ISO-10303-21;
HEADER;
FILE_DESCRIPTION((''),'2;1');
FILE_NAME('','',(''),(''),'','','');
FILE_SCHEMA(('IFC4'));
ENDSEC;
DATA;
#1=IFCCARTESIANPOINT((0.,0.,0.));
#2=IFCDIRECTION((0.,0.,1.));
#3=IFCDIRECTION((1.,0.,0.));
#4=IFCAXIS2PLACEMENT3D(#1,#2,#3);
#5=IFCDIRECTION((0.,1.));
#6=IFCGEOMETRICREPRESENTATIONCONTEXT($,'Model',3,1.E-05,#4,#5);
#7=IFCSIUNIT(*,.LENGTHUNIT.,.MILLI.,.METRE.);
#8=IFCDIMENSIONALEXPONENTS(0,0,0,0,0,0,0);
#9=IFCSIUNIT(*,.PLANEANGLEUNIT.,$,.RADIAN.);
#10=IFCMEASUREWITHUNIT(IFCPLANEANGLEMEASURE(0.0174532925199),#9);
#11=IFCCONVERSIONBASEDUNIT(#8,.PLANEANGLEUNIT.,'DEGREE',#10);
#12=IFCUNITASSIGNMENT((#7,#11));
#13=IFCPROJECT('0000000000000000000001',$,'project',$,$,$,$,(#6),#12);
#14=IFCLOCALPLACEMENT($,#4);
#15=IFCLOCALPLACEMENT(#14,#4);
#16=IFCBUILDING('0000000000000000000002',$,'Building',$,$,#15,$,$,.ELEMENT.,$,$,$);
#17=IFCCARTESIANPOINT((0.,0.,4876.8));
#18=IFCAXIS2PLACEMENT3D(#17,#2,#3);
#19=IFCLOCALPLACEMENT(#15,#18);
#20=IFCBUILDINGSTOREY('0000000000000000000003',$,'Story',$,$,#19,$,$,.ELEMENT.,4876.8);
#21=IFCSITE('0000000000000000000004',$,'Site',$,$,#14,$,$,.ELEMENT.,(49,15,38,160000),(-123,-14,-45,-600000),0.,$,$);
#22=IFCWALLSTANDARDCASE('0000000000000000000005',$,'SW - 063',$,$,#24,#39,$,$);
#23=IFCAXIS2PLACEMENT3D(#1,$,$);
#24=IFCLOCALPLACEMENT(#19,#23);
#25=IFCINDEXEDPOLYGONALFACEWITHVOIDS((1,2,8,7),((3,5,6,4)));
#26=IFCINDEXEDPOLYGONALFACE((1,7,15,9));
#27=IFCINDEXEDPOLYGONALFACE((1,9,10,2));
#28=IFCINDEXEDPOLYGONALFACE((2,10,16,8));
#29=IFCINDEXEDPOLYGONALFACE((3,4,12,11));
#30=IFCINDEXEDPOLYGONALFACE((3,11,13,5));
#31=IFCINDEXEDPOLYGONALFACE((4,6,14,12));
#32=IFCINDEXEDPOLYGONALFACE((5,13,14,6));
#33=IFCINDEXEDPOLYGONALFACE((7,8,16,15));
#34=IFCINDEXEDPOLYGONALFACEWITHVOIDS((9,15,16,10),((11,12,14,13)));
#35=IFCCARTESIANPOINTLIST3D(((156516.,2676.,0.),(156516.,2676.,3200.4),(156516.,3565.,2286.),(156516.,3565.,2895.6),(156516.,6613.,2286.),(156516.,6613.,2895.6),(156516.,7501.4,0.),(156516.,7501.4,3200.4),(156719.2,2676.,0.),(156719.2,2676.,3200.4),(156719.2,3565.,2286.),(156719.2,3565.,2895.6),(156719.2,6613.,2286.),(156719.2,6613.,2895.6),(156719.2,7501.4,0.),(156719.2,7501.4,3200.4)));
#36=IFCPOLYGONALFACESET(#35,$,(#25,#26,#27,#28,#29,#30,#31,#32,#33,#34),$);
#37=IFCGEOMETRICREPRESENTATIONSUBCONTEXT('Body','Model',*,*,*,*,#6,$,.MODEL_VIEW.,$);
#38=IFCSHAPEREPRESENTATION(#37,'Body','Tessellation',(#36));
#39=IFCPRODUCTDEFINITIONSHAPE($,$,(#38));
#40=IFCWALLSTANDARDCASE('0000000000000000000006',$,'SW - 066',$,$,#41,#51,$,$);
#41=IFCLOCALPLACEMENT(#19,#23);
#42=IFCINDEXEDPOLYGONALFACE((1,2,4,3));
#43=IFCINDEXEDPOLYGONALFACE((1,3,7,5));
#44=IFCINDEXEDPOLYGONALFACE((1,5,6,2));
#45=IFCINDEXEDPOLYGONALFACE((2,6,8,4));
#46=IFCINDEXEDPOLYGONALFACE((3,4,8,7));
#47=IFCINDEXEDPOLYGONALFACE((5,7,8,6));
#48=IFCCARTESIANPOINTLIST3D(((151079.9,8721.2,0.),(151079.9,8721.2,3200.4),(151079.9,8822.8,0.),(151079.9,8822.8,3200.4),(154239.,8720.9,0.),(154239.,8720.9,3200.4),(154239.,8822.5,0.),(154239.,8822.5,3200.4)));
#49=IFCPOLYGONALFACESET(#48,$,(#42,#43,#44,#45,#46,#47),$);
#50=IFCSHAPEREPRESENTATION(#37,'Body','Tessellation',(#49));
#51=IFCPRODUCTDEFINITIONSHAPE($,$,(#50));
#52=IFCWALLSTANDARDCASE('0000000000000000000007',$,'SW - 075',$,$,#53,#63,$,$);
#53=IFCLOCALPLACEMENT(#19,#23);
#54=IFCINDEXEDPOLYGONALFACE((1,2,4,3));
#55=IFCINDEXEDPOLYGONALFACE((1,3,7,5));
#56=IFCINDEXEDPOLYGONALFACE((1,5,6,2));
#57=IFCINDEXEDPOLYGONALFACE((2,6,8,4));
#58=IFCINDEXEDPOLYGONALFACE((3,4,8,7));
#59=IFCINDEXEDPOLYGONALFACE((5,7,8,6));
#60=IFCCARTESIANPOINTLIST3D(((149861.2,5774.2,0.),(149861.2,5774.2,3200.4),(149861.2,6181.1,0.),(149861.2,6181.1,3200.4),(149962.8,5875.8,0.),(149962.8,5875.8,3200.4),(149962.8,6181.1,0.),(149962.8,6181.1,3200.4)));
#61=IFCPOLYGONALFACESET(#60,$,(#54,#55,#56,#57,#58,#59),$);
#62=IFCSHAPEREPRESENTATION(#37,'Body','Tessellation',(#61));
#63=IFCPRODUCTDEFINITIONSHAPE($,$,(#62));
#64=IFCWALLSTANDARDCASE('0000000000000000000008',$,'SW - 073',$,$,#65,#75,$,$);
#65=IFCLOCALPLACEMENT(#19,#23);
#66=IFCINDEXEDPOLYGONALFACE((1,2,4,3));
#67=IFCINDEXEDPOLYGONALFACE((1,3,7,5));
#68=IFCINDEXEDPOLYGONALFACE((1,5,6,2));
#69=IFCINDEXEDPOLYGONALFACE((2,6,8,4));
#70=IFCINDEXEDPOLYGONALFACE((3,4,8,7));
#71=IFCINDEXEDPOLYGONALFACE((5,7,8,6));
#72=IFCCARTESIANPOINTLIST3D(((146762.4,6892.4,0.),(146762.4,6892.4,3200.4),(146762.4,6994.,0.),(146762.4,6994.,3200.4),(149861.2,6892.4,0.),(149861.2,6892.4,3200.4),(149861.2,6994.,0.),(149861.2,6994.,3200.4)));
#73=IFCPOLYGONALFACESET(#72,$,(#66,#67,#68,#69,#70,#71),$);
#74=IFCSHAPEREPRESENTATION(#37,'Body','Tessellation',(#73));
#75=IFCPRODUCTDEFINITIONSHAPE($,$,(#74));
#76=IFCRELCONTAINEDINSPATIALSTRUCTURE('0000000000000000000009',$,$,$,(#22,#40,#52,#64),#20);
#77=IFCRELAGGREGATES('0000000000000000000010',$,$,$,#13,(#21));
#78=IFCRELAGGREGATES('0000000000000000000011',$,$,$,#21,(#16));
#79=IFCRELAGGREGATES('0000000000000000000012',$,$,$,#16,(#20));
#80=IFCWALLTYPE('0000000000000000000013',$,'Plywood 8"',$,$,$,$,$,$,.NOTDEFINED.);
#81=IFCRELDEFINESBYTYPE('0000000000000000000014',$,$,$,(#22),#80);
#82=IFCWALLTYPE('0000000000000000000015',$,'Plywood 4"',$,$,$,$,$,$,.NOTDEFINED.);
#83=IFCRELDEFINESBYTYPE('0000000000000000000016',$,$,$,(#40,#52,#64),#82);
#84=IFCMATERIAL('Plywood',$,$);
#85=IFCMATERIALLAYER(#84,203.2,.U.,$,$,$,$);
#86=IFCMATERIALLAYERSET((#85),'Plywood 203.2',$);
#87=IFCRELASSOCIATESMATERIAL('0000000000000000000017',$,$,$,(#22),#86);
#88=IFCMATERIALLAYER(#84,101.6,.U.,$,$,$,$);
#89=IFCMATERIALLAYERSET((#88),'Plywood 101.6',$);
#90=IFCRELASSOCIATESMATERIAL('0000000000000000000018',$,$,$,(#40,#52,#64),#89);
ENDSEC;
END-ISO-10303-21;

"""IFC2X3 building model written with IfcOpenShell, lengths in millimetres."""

from ifc_helpers import new_model, entity, si_unit, converted_unit, direction, frame, origin_with_axes, origin_2d_with_axis, place, context, subcontext, project, spatial, polyline, rectangle, outline, extrude, material, layer, layer_set, layer_usage, type_object, element, save


model = new_model("IFC2X3")

# Units and contexts
model_context = context("Model", 3, precision=1e-05, world=origin_with_axes(), true_north=direction((0.0, 1.0)))
body_context = subcontext(model_context, "Body", "Model", "MODEL_VIEW")
ifc_project = project(units=[si_unit("LENGTHUNIT", "METRE", prefix="MILLI"), converted_unit("PLANEANGLEUNIT", "DEGREE", entity("IfcPlaneAngleMeasure", 0.0174532925199), si_unit("PLANEANGLEUNIT", "RADIAN"), dimensions=[0, 0, 0, 0, 0, 0, 0])], contexts=[model_context])

# Site, building, storey
site_placement = place(None, origin_with_axes())
site = spatial("IfcSite", under=ifc_project, at=site_placement, Name="Site", CompositionType="ELEMENT", RefLatitude=(49, 15, 38, 160000), RefLongitude=(-123, -14, -45, -600000), RefElevation=0.0)
building_placement = place(site_placement, origin_with_axes())
building = spatial("IfcBuilding", under=site, at=building_placement, Name="Building", CompositionType="ELEMENT")
storey_placement = place(building_placement, frame((0.0, 0.0, 4876.8), z_axis=(0.0, 0.0, 1.0), x_axis=(1.0, 0.0, 0.0)))
storey = spatial("IfcBuildingStorey", under=building, at=storey_placement, Name="Story", CompositionType="ELEMENT", Elevation=4876.8)

# Shared definitions
ifc_material_1 = material(Name="Plywood")
ifc_layer_1 = layer(ifc_material_1, 203.2, ventilated="UNKNOWN")
ifc_layer_set_1 = layer_set([ifc_layer_1], Name="Plywood 203.2")
wall_type_1 = type_object("IfcWallType", Name="Plywood 8\"", PredefinedType="NOTDEFINED")

# Wall, opening
ifc_layer_usage_1 = layer_usage(ifc_layer_set_1, "AXIS2", "POSITIVE", 0.0)
wall_1_placement = place(storey_placement, frame((156516.0, 7501.4, 0.0), z_axis=(0.0, 0.0, 1.0), x_axis=(0.0, -1.0, 0.0)))
wall_1 = element("IfcWallStandardCase", 1, at=wall_1_placement, inside=storey, type_object=wall_type_1, material=ifc_layer_usage_1, Name="SW - 063", context=body_context, shape_type="SweptSolid", body=[
    extrude(outline(polyline([(0.0, 0.0), (4825.5, 0.0), (4825.5, 203.2), (0.0, 203.2), (0.0, 0.0)])), origin_with_axes(), (0.0, 0.0, 1.0), 3200.4),
])
opening_1_placement = place(wall_1_placement, frame((2412.5, 0.0, 2286.0), z_axis=(0.0, 0.0, 1.0), x_axis=(1.0, 0.0, 0.0)))
element("IfcOpeningElement", 2, at=opening_1_placement, cuts=wall_1, context=body_context, shape_type="SweptSolid", body=[
    extrude(rectangle(XDim=3048.0, YDim=609.6, at=origin_2d_with_axis()), frame((0.0, -203.2, 304.8), z_axis=(0.0, -1.0, 0.0), x_axis=(-1.0, 0.0, 0.0)), (0.0, 0.0, -1.0), 609.6),
])

# Shared definitions
ifc_layer_2 = layer(ifc_material_1, 101.6, ventilated="UNKNOWN")
ifc_layer_set_2 = layer_set([ifc_layer_2], Name="Plywood 101.6")
wall_type_2 = type_object("IfcWallType", Name="Plywood 4\"", PredefinedType="NOTDEFINED")

# Walls
ifc_layer_usage_2 = layer_usage(ifc_layer_set_2, "AXIS2", "POSITIVE", 0.0)
wall_2_placement = place(storey_placement, frame((151079.9, 8721.2, 0.0), z_axis=(0.0, 0.0, 1.0), x_axis=(1.0, -0.000087, 0.0)))
element("IfcWallStandardCase", 3, at=wall_2_placement, inside=storey, type_object=wall_type_2, material=ifc_layer_usage_2, Name="SW - 066", context=body_context, shape_type="SweptSolid", body=[
    extrude(outline(polyline([(0.0, 0.0), (3159.2, 0.0), (3159.2, 101.6), (0.0, 101.6), (0.0, 0.0)])), origin_with_axes(), (0.0, 0.0, 1.0), 3200.4),
])
ifc_layer_usage_3 = layer_usage(ifc_layer_set_2, "AXIS2", "POSITIVE", 0.0)
wall_3_placement = place(storey_placement, frame((149861.2, 6181.1, 0.0), z_axis=(0.0, 0.0, 1.0), x_axis=(0.0, -1.0, 0.0)))
element("IfcWallStandardCase", 4, at=wall_3_placement, inside=storey, type_object=wall_type_2, material=ifc_layer_usage_3, Name="SW - 075", context=body_context, shape_type="SweptSolid", body=[
    extrude(outline(polyline([(0.0, 0.0), (406.9, 0.0), (305.3, 101.6), (0.0, 101.6), (0.0, 0.0)])), origin_with_axes(), (0.0, 0.0, 1.0), 3200.4),
])

# Wall
ifc_layer_usage_4 = layer_usage(ifc_layer_set_2, "AXIS2", "POSITIVE", 0.0)
wall_4_placement = place(storey_placement, frame((149861.2, 6994.0, 0.0), z_axis=(0.0, 0.0, 1.0), x_axis=(-1.0, 0.0, 0.0)))
element("IfcWallStandardCase", 5, at=wall_4_placement, inside=storey, type_object=wall_type_2, material=ifc_layer_usage_4, Name="SW - 073", context=body_context, shape_type="SweptSolid", body=[
    extrude(outline(polyline([(0.0, 0.0), (3098.8, 0.0), (3098.8, 101.6), (0.0, 101.6), (0.0, 0.0)])), origin_with_axes(), (0.0, 0.0, 1.0), 3200.4),
])

save(model, "model.ifc")
